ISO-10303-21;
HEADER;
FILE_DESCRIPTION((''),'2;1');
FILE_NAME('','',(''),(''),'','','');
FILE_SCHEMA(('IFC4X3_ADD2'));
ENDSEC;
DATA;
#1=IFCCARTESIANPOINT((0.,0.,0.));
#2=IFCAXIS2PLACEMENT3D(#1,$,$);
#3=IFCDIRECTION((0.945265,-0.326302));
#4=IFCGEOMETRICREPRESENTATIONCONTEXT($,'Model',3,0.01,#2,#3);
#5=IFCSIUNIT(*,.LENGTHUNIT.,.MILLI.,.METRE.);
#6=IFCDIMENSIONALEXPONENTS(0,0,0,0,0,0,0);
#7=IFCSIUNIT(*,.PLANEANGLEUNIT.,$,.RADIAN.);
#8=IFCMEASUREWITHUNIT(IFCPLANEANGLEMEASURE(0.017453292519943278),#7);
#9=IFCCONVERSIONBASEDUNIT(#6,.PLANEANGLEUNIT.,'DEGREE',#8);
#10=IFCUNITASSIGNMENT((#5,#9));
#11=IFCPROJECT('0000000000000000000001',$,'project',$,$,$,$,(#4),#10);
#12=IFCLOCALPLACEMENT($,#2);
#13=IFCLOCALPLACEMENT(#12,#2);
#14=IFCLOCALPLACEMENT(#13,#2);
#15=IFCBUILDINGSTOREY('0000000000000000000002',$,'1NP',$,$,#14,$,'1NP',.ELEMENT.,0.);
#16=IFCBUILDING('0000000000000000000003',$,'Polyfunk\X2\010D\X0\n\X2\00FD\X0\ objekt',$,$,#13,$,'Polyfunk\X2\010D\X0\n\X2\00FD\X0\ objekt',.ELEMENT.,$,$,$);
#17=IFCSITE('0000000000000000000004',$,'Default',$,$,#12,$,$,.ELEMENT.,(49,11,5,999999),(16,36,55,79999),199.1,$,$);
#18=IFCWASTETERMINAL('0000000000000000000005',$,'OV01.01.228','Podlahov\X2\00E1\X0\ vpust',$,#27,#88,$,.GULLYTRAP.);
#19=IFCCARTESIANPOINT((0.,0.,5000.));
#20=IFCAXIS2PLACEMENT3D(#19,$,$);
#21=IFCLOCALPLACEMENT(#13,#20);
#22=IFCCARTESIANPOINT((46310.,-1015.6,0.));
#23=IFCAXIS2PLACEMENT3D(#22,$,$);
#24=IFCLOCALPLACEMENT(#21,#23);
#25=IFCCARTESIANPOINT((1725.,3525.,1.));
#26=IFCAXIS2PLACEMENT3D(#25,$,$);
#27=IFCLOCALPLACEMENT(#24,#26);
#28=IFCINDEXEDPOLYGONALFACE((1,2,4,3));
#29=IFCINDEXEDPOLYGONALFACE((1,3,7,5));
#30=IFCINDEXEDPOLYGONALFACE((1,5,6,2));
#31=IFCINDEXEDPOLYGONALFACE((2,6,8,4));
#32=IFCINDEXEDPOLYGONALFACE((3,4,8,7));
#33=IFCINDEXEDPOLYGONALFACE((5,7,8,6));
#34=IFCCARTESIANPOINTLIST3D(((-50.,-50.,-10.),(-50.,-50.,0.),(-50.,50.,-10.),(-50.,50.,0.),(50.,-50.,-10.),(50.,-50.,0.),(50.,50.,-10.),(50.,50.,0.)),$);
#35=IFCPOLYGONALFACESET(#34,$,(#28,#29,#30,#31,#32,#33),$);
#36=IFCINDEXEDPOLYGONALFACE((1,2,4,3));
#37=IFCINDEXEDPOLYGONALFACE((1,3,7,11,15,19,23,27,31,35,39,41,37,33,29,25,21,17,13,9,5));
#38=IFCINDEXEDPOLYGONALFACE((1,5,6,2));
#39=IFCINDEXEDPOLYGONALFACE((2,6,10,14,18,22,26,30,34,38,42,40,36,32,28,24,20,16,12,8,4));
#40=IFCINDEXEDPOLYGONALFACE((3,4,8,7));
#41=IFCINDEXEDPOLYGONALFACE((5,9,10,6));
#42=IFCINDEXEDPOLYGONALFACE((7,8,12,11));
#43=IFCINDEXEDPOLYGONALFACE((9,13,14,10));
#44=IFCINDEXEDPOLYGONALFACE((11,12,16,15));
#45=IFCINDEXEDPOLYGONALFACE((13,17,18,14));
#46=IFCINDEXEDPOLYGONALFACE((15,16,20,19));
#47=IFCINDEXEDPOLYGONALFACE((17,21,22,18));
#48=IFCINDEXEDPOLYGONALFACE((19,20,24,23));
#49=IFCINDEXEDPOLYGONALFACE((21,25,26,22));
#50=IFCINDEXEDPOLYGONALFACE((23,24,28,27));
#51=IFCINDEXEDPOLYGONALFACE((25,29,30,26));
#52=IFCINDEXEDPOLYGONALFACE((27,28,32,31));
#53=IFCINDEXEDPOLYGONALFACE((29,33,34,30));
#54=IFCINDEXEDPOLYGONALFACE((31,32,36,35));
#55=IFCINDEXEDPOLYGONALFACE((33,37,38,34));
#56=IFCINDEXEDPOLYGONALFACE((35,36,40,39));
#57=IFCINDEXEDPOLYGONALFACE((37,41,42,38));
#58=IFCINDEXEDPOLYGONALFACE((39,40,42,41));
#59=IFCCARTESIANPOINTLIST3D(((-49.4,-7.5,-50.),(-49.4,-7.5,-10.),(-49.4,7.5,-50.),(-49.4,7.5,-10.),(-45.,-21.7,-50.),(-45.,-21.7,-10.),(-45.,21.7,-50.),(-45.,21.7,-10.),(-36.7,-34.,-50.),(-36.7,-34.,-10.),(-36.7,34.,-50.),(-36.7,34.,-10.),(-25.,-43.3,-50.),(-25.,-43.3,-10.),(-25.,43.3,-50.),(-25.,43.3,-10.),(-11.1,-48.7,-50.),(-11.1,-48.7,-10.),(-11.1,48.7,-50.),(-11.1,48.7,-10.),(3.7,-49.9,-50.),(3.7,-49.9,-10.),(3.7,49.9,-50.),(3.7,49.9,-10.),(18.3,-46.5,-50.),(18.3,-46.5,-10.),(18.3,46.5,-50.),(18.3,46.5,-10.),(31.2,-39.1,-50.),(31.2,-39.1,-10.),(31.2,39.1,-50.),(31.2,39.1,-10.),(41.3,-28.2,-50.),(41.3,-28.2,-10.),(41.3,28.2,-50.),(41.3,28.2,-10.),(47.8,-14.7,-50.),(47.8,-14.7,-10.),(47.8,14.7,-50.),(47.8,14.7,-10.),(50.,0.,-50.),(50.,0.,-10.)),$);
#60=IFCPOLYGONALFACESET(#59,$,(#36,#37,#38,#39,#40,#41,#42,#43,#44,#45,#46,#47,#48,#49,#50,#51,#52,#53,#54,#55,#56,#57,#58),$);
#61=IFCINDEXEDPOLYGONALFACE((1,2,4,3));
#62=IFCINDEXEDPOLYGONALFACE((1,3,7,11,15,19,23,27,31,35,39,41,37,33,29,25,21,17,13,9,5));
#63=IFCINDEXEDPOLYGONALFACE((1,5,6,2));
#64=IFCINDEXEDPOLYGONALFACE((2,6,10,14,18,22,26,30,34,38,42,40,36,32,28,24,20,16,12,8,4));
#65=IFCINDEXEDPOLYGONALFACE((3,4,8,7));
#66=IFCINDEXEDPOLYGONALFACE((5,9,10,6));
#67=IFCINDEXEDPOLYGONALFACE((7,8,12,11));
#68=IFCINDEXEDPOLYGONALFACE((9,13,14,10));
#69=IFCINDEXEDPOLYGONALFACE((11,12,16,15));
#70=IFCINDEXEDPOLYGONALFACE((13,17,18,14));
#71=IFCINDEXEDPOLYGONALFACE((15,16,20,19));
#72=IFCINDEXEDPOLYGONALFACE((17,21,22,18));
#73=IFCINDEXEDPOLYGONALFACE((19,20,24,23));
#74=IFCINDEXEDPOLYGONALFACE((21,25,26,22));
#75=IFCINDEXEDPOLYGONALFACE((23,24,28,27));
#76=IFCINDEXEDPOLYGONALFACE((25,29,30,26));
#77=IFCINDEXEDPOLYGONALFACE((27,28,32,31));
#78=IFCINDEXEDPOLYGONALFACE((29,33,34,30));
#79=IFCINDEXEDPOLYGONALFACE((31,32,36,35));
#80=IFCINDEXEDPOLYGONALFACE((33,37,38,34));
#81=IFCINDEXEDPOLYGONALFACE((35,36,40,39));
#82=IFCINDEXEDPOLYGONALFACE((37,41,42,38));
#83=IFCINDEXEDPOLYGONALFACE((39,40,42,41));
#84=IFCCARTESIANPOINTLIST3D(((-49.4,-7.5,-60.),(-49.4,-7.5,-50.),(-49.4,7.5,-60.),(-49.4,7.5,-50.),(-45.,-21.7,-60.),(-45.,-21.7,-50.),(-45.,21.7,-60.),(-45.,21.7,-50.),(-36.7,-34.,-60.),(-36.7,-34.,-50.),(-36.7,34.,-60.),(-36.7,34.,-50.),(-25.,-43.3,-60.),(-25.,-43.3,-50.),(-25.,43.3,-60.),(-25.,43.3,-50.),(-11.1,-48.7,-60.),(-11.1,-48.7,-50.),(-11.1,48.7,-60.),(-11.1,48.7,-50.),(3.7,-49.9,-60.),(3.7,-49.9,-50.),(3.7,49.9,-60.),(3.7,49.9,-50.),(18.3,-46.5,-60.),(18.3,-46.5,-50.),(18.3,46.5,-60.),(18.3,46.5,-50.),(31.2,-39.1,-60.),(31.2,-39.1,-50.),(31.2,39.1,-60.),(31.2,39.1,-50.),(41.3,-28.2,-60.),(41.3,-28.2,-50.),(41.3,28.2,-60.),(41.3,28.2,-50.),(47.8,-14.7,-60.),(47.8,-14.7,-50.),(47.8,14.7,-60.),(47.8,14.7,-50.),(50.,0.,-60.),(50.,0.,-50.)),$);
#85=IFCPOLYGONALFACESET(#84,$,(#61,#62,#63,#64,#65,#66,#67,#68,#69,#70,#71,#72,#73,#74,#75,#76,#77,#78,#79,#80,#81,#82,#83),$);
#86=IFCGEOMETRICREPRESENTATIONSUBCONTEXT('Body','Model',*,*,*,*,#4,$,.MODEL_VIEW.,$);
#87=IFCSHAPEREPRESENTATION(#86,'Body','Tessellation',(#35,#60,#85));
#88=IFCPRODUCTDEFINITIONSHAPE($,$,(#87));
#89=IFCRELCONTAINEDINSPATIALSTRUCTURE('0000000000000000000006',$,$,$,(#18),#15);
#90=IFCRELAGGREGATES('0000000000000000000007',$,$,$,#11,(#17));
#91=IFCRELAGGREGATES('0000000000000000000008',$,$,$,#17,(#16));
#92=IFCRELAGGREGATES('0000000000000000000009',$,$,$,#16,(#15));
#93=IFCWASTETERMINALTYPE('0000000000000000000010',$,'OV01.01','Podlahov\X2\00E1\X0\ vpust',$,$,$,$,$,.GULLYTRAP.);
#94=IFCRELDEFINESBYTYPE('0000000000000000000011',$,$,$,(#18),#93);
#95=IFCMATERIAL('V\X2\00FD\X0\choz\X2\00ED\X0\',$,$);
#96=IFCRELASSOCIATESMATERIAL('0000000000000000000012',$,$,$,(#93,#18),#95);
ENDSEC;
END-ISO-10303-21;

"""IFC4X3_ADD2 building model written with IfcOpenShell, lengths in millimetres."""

from ifc_helpers import new_model, entity, si_unit, converted_unit, direction, frame, frame_2d, origin, place, context, subcontext, project, spatial, rectangle, circle, extrude, source, transform, mapped, material, type_object, type_shapes, element, save


model = new_model("IFC4X3_ADD2")

# Units and contexts
model_context = context("Model", 3, precision=0.01, world=origin(), true_north=direction((0.945265, -0.326302)))
body_context = subcontext(model_context, "Body", "Model", "MODEL_VIEW")
ifc_project = project(units=[si_unit("LENGTHUNIT", "METRE", prefix="MILLI"), converted_unit("PLANEANGLEUNIT", "DEGREE", entity("IfcPlaneAngleMeasure", 0.017453292519943278), si_unit("PLANEANGLEUNIT", "RADIAN"), dimensions=[0, 0, 0, 0, 0, 0, 0])], contexts=[model_context])

# Site, building, storey
site_placement = place(None, origin())
site = spatial("IfcSite", under=ifc_project, at=site_placement, Name="Default", CompositionType="ELEMENT", RefLatitude=(49, 11, 5, 999999), RefLongitude=(16, 36, 55, 79999), RefElevation=199.1)
building_placement = place(site_placement, origin())
building = spatial("IfcBuilding", under=site, at=building_placement, Name="Polyfunkčný objekt", LongName="Polyfunkčný objekt", CompositionType="ELEMENT")
storey_placement = place(building_placement, origin())
storey = spatial("IfcBuildingStorey", under=building, at=storey_placement, Name="1NP", LongName="1NP", CompositionType="ELEMENT", Elevation=0.0)

# Waste terminal
ifc_material_1 = material(Name="Výchozí")
waste_terminal_type = type_object("IfcWasteTerminalType", Name="OV01.01", Description="Podlahová vpust", PredefinedType="GULLYTRAP", material=ifc_material_1)
shared_shape_1 = source(origin(), body_context, "Body", "SweptSolid", [
    extrude(rectangle(XDim=100.0, YDim=100.0, at=frame_2d((0.0, 0.0), x_axis=(1.0, 0.0))), frame((0.0, 0.0, -10.0), z_axis=(0.0, 0.0, 1.0), x_axis=(-1.0, 0.0, 0.0)), (0.0, 0.0, 1.0), 10.0),
    extrude(circle(Radius=50.0, at=frame_2d((0.0, 0.0), x_axis=(1.0, 0.0))), frame((0.0, 0.0, -50.0)), (0.0, 0.0, 1.0), 40.0),
    extrude(circle(Radius=50.0, at=frame_2d((0.0, 0.0), x_axis=(1.0, 0.0))), frame((0.0, 0.0, -60.0)), (0.0, 0.0, 1.0), 10.0),
])
type_shapes(waste_terminal_type, [shared_shape_1])
placement_1 = place(building_placement, frame((0.0, 0.0, 5000.0)))
placement_2 = place(placement_1, frame((46310.0, -1015.6, 0.0)))
waste_terminal_1_placement = place(placement_2, frame((1725.0, 3525.0, 1.0)))
element("IfcWasteTerminal", 1, at=waste_terminal_1_placement, inside=storey, type_object=waste_terminal_type, material=ifc_material_1, Name="OV01.01.228", Description="Podlahová vpust", PredefinedType="GULLYTRAP", context=body_context, shape_type="MappedRepresentation", body=[
    mapped(shared_shape_1, transform((0.0, 0.0, 0.0), scale=1.0)),
])

save(model, "model.ifc")
